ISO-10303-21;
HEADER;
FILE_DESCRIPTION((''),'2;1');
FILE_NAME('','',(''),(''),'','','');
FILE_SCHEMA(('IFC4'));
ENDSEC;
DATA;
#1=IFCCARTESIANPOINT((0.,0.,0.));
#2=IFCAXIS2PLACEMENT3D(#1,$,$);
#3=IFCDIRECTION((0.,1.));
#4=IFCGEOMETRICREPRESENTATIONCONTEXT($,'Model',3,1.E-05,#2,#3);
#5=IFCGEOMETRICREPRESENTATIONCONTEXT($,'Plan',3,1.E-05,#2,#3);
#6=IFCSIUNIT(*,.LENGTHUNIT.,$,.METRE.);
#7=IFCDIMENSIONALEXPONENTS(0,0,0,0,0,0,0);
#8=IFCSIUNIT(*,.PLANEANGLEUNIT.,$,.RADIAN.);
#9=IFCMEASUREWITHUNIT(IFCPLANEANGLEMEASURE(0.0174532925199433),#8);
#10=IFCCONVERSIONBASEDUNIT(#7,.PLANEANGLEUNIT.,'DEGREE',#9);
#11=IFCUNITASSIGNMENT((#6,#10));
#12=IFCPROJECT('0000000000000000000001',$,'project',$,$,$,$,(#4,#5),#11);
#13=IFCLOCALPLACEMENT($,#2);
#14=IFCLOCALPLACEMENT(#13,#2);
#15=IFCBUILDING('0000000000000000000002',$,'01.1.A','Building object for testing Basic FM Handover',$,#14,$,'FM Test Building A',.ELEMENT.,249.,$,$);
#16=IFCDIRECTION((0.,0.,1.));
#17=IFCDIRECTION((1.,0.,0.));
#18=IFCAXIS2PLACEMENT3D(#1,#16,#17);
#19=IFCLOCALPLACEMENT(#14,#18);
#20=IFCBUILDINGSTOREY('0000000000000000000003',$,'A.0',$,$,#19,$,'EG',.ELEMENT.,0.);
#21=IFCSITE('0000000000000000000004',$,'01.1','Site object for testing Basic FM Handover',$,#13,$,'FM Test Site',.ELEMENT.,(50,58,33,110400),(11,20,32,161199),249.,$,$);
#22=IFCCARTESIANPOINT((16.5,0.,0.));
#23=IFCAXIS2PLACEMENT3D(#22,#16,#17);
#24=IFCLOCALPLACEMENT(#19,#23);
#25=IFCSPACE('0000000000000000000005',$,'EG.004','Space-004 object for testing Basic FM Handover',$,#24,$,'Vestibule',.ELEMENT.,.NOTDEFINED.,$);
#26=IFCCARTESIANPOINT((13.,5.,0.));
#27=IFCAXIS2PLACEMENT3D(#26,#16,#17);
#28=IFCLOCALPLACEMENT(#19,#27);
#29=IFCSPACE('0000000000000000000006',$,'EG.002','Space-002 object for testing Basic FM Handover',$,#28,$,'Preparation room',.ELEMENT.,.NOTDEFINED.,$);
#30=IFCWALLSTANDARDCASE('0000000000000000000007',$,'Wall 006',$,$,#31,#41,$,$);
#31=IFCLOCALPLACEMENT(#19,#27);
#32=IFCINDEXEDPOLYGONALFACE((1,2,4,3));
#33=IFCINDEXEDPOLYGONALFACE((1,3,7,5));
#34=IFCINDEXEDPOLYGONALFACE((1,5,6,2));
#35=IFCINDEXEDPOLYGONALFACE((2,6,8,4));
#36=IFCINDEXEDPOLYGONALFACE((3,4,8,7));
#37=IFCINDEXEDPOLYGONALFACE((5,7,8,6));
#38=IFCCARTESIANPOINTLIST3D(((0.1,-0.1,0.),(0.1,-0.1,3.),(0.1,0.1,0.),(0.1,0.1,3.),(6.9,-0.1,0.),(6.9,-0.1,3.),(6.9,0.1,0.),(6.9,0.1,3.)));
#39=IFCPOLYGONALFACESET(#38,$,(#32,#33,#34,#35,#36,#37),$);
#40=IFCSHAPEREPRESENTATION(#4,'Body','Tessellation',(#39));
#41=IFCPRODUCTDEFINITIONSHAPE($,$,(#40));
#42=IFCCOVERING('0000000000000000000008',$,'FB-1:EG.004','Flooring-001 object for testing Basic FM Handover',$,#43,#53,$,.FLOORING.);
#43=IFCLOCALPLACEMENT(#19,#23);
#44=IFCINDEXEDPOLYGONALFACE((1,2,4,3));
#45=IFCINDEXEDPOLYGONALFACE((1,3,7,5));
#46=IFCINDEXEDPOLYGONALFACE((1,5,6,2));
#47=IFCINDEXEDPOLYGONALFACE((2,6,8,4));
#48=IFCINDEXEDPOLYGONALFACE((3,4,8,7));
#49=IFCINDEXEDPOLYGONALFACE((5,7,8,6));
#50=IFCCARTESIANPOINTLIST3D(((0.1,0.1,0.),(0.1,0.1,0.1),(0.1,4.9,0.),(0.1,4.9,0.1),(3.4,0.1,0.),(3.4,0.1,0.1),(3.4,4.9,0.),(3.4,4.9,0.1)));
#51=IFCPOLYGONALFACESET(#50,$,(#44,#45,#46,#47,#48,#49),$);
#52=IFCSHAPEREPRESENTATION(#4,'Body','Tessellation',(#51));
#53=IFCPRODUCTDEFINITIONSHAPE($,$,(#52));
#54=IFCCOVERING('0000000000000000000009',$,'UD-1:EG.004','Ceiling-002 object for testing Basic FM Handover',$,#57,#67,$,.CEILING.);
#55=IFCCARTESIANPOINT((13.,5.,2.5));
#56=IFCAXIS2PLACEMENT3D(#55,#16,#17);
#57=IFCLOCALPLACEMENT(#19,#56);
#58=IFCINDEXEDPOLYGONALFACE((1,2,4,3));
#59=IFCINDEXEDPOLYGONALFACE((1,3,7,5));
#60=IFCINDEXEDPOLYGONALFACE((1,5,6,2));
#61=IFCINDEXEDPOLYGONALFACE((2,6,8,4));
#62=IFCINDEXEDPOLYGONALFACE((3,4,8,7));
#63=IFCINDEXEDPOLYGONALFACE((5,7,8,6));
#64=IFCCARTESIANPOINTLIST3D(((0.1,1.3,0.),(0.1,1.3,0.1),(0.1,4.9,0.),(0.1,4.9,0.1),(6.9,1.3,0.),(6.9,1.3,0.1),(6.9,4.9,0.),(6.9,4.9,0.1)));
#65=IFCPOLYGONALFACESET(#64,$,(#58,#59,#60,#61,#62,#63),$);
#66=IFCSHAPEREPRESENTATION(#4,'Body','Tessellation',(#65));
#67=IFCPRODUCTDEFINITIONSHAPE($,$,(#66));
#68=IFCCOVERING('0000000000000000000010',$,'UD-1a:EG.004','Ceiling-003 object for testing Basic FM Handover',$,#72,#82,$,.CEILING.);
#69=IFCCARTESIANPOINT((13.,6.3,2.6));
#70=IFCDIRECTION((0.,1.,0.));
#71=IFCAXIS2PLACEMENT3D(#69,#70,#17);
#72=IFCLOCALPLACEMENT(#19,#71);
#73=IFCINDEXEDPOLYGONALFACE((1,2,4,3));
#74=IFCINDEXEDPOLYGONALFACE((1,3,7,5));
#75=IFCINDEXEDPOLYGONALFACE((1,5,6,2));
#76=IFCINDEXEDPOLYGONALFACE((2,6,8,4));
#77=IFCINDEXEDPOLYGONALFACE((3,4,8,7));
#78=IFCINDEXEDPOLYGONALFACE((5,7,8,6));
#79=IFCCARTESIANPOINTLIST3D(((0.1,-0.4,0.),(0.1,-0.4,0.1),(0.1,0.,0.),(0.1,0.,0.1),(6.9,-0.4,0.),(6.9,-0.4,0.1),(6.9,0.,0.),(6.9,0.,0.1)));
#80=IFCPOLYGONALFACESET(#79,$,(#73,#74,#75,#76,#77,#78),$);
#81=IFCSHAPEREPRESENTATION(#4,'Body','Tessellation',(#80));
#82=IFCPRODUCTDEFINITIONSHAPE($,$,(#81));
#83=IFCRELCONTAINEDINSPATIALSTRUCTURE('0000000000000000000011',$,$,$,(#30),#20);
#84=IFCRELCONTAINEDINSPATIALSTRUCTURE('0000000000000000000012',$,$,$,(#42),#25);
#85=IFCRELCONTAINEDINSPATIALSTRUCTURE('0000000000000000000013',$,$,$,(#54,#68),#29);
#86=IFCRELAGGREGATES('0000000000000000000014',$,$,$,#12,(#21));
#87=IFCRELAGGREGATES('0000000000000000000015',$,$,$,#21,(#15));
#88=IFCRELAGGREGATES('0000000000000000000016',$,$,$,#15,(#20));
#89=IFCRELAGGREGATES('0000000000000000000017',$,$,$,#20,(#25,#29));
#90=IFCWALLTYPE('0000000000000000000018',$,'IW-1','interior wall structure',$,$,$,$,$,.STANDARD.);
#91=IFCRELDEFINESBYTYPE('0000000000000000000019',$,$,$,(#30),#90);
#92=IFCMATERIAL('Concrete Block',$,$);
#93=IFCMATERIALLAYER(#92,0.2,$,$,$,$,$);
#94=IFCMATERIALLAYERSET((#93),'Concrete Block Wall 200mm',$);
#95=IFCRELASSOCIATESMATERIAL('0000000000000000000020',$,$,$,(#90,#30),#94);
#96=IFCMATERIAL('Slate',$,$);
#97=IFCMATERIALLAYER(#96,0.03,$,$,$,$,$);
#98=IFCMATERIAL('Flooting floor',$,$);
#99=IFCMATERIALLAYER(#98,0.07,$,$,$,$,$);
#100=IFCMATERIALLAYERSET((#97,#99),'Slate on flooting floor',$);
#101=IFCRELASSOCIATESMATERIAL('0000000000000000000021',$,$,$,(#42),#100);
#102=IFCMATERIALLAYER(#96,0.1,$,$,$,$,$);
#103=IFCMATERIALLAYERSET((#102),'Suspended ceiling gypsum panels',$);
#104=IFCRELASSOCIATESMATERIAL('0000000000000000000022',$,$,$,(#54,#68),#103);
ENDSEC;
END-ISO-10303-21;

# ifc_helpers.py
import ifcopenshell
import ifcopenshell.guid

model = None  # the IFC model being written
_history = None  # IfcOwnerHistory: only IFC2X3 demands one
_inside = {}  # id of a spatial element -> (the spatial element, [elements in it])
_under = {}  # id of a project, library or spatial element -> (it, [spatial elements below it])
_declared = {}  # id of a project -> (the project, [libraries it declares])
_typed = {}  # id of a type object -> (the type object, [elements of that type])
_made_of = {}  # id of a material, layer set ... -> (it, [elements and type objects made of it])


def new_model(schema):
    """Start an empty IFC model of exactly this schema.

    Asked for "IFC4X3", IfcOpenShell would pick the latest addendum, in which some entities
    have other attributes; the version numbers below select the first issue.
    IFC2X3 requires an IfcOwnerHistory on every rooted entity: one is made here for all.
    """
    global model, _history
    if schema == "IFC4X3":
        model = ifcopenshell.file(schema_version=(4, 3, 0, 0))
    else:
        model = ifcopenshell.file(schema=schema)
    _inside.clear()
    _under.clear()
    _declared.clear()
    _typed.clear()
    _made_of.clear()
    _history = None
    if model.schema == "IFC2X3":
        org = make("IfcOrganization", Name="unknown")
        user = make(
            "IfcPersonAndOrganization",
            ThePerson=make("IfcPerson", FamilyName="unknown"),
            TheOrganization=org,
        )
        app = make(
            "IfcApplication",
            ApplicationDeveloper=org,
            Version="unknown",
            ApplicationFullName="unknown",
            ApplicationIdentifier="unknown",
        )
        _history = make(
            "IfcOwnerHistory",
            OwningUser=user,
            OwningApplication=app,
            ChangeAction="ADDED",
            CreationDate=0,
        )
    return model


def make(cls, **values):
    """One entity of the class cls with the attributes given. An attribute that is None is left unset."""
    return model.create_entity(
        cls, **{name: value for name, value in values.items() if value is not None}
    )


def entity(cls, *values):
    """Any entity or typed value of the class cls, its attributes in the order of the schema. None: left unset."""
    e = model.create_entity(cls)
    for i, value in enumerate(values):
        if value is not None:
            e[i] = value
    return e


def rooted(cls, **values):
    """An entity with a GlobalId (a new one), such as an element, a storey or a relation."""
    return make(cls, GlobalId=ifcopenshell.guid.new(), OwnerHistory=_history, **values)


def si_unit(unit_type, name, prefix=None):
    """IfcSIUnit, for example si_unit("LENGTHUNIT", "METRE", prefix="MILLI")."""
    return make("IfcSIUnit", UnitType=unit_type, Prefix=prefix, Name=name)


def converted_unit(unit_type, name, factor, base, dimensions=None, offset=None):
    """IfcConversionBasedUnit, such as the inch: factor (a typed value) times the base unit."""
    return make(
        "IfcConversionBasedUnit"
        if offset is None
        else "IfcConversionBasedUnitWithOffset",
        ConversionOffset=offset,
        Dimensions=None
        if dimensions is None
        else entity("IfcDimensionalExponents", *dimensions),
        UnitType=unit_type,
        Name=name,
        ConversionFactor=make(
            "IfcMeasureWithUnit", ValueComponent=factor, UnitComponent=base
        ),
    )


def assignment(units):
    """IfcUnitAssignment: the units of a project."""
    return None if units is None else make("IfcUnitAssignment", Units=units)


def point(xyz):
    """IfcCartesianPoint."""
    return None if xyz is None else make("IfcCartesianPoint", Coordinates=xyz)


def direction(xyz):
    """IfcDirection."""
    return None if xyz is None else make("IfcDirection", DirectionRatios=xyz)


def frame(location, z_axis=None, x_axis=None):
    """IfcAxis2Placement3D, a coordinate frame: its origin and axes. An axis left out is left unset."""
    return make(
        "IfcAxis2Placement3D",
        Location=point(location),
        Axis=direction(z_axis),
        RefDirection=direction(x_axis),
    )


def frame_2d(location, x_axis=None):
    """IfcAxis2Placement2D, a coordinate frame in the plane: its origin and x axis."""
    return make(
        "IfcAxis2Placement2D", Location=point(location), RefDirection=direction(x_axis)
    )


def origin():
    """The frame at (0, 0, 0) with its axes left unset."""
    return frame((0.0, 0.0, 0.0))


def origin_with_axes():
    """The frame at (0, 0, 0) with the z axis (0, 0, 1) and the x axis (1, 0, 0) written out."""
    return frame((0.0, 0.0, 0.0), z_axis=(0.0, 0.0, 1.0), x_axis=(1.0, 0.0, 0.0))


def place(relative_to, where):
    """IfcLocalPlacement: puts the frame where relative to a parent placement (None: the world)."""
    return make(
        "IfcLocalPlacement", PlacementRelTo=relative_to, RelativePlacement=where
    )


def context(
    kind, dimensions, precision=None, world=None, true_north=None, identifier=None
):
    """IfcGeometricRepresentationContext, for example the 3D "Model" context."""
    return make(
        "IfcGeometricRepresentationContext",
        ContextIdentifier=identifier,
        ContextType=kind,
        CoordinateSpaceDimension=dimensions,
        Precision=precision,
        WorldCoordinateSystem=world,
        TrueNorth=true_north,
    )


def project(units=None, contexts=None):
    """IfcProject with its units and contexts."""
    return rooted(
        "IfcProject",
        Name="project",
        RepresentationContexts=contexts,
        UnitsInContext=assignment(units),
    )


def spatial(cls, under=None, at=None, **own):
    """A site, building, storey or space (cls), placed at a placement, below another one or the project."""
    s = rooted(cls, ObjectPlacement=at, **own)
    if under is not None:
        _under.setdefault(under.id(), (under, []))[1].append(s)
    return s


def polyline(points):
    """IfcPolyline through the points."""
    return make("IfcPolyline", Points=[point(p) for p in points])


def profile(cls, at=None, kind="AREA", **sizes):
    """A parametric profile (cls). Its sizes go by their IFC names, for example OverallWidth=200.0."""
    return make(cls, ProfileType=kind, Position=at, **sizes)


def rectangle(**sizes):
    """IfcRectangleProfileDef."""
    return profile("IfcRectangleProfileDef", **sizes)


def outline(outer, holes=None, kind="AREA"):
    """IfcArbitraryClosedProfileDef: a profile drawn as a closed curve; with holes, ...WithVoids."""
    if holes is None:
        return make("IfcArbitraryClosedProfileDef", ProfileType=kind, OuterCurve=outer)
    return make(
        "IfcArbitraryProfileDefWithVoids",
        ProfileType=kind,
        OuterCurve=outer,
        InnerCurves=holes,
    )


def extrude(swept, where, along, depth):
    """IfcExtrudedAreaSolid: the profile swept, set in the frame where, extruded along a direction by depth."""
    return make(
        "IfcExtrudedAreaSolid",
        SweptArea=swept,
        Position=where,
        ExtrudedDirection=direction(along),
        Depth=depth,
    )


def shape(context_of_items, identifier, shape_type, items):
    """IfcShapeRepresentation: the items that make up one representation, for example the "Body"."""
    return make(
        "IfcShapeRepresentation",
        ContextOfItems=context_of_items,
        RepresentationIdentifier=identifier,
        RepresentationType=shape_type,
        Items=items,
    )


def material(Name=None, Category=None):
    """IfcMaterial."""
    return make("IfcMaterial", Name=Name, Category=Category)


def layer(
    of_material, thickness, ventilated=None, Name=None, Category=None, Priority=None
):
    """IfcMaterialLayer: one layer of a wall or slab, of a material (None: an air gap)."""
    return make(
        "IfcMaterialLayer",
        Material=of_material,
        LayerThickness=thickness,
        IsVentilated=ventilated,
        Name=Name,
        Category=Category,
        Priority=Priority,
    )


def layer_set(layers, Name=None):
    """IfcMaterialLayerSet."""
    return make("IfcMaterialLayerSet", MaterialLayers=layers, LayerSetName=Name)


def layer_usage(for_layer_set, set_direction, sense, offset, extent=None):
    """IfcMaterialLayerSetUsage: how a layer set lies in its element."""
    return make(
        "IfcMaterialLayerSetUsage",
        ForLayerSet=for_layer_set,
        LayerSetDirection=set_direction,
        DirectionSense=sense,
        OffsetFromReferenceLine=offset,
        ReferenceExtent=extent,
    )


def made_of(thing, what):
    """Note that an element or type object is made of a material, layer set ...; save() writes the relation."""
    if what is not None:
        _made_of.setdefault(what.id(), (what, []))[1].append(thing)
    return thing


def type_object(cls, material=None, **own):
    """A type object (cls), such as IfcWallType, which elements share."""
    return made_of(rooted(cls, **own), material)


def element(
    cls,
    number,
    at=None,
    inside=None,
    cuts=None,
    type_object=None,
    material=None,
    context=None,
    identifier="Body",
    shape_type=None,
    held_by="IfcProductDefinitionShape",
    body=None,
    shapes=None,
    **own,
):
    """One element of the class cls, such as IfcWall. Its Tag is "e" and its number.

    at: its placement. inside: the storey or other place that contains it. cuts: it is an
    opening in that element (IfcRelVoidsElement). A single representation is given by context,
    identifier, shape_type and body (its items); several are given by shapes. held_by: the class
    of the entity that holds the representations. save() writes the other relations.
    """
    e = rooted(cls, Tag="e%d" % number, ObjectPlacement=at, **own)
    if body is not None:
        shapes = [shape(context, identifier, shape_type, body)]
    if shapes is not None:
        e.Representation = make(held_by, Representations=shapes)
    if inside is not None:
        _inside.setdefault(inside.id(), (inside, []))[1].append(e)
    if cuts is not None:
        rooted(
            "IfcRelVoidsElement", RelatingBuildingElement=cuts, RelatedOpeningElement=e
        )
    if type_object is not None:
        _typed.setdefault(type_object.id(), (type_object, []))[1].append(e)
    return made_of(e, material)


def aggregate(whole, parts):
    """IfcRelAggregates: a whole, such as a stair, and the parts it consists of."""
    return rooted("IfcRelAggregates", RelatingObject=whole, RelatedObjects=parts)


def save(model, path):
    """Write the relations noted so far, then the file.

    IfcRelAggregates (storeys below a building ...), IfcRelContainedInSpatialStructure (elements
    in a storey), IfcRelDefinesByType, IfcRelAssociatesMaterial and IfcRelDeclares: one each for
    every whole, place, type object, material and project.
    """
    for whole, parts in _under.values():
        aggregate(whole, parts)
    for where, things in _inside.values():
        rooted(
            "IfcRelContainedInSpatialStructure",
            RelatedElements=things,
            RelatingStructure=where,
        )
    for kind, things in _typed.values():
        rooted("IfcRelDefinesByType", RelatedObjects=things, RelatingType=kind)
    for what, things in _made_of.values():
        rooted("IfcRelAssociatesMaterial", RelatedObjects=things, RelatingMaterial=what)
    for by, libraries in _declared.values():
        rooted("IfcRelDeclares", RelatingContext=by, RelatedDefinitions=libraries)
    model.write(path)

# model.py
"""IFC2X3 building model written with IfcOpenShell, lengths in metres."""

from ifc_helpers import new_model, entity, si_unit, converted_unit, direction, frame, frame_2d, origin, origin_with_axes, place, context, project, spatial, polyline, rectangle, outline, extrude, material, layer, layer_set, layer_usage, type_object, element, save


model = new_model("IFC2X3")

# Units and contexts
model_context = context("Model", 3, precision=1e-05, world=origin(), true_north=direction((0.0, 1.0)))
plan_context = context("Plan", 3, precision=1e-05, world=origin(), true_north=direction((0.0, 1.0)))
ifc_project = project(units=[si_unit("LENGTHUNIT", "METRE"), converted_unit("PLANEANGLEUNIT", "DEGREE", entity("IfcPlaneAngleMeasure", 0.0174532925199433), si_unit("PLANEANGLEUNIT", "RADIAN"), dimensions=[0, 0, 0, 0, 0, 0, 0])], contexts=[model_context, plan_context])

# Site, building, storey
site_placement = place(None, origin())
site = spatial("IfcSite", under=ifc_project, at=site_placement, Name="01.1", Description="Site object for testing Basic FM Handover", LongName="FM Test Site", CompositionType="ELEMENT", RefLatitude=(50, 58, 33, 110400), RefLongitude=(11, 20, 32, 161199), RefElevation=249.0)
building_placement = place(site_placement, origin())
building = spatial("IfcBuilding", under=site, at=building_placement, Name="01.1.A", Description="Building object for testing Basic FM Handover", LongName="FM Test Building A", CompositionType="ELEMENT", ElevationOfRefHeight=249.0)
storey_placement = place(building_placement, origin_with_axes())
storey = spatial("IfcBuildingStorey", under=building, at=storey_placement, Name="A.0", LongName="EG", CompositionType="ELEMENT", Elevation=0.0)

# Shared definitions
space_1_placement = place(storey_placement, frame((16.5, 0.0, 0.0), z_axis=(0.0, 0.0, 1.0), x_axis=(1.0, 0.0, 0.0)))
space_1 = spatial("IfcSpace", under=storey, at=space_1_placement, Name="EG.004", Description="Space-004 object for testing Basic FM Handover", LongName="Vestibule", CompositionType="ELEMENT", InteriorOrExteriorSpace="NOTDEFINED")

# Shared definitions
ifc_material_1 = material(Name="Concrete Block")
ifc_layer_1 = layer(ifc_material_1, 0.2)
ifc_layer_set_1 = layer_set([ifc_layer_1], Name="Concrete Block Wall 200mm")
wall_type_1 = type_object("IfcWallType", Name="IW-1", Description="interior wall structure", PredefinedType="STANDARD", material=ifc_layer_set_1)

# Wall
ifc_layer_usage_1 = layer_usage(ifc_layer_set_1, "AXIS2", "POSITIVE", -0.1)
wall_1_placement = place(storey_placement, frame((13.0, 5.0, 0.0), z_axis=(0.0, 0.0, 1.0), x_axis=(1.0, 0.0, 0.0)))
element("IfcWallStandardCase", 1, at=wall_1_placement, inside=storey, type_object=wall_type_1, material=ifc_layer_usage_1, Name="Wall 006", context=model_context, shape_type="SweptSolid", body=[
    extrude(rectangle(XDim=6.8, YDim=0.2, at=frame_2d((3.5, 0.0))), origin(), (0.0, 0.0, 1.0), 3.0),
])

# Covering
ifc_material_2 = material(Name="Slate")
ifc_layer_2 = layer(ifc_material_2, 0.03)
ifc_material_3 = material(Name="Flooting floor")
ifc_layer_3 = layer(ifc_material_3, 0.07)
ifc_layer_set_2 = layer_set([ifc_layer_2, ifc_layer_3], Name="Slate on flooting floor")
covering_1_placement = place(storey_placement, frame((16.5, 0.0, 0.0), z_axis=(0.0, 0.0, 1.0), x_axis=(1.0, 0.0, 0.0)))
element("IfcCovering", 2, at=covering_1_placement, inside=space_1, material=ifc_layer_set_2, Name="FB-1:EG.004", Description="Flooring-001 object for testing Basic FM Handover", PredefinedType="FLOORING", context=model_context, shape_type="SweptSolid", body=[
    extrude(outline(polyline([(0.1, 0.1), (3.4, 0.1), (3.4, 4.9), (0.1, 4.9), (0.1, 0.1)])), origin(), (0.0, 0.0, 1.0), 0.1),
])

# Shared definitions
space_2_placement = place(storey_placement, frame((13.0, 5.0, 0.0), z_axis=(0.0, 0.0, 1.0), x_axis=(1.0, 0.0, 0.0)))
space_2 = spatial("IfcSpace", under=storey, at=space_2_placement, Name="EG.002", Description="Space-002 object for testing Basic FM Handover", LongName="Preparation room", CompositionType="ELEMENT", InteriorOrExteriorSpace="NOTDEFINED")

# Coverings
ifc_layer_4 = layer(ifc_material_2, 0.1)
ifc_layer_set_3 = layer_set([ifc_layer_4], Name="Suspended ceiling gypsum panels")
covering_2_placement = place(storey_placement, frame((13.0, 5.0, 2.5), z_axis=(0.0, 0.0, 1.0), x_axis=(1.0, 0.0, 0.0)))
element("IfcCovering", 3, at=covering_2_placement, inside=space_2, material=ifc_layer_set_3, Name="UD-1:EG.004", Description="Ceiling-002 object for testing Basic FM Handover", PredefinedType="CEILING", context=model_context, shape_type="SweptSolid", body=[
    extrude(outline(polyline([(0.1, 1.3), (6.9, 1.3), (6.9, 4.9), (0.1, 4.9), (0.1, 1.3)])), origin(), (0.0, 0.0, 1.0), 0.1),
])
covering_3_placement = place(storey_placement, frame((13.0, 6.3, 2.6), z_axis=(0.0, 1.0, 0.0), x_axis=(1.0, 0.0, 0.0)))
element("IfcCovering", 4, at=covering_3_placement, inside=space_2, material=ifc_layer_set_3, Name="UD-1a:EG.004", Description="Ceiling-003 object for testing Basic FM Handover", PredefinedType="CEILING", context=model_context, shape_type="SweptSolid", body=[
    extrude(outline(polyline([(0.1, 0.0), (6.9, 0.0), (6.9, -0.4), (0.1, -0.4), (0.1, 0.0)])), origin(), (0.0, 0.0, 1.0), 0.1),
])

save(model, "model.ifc")
